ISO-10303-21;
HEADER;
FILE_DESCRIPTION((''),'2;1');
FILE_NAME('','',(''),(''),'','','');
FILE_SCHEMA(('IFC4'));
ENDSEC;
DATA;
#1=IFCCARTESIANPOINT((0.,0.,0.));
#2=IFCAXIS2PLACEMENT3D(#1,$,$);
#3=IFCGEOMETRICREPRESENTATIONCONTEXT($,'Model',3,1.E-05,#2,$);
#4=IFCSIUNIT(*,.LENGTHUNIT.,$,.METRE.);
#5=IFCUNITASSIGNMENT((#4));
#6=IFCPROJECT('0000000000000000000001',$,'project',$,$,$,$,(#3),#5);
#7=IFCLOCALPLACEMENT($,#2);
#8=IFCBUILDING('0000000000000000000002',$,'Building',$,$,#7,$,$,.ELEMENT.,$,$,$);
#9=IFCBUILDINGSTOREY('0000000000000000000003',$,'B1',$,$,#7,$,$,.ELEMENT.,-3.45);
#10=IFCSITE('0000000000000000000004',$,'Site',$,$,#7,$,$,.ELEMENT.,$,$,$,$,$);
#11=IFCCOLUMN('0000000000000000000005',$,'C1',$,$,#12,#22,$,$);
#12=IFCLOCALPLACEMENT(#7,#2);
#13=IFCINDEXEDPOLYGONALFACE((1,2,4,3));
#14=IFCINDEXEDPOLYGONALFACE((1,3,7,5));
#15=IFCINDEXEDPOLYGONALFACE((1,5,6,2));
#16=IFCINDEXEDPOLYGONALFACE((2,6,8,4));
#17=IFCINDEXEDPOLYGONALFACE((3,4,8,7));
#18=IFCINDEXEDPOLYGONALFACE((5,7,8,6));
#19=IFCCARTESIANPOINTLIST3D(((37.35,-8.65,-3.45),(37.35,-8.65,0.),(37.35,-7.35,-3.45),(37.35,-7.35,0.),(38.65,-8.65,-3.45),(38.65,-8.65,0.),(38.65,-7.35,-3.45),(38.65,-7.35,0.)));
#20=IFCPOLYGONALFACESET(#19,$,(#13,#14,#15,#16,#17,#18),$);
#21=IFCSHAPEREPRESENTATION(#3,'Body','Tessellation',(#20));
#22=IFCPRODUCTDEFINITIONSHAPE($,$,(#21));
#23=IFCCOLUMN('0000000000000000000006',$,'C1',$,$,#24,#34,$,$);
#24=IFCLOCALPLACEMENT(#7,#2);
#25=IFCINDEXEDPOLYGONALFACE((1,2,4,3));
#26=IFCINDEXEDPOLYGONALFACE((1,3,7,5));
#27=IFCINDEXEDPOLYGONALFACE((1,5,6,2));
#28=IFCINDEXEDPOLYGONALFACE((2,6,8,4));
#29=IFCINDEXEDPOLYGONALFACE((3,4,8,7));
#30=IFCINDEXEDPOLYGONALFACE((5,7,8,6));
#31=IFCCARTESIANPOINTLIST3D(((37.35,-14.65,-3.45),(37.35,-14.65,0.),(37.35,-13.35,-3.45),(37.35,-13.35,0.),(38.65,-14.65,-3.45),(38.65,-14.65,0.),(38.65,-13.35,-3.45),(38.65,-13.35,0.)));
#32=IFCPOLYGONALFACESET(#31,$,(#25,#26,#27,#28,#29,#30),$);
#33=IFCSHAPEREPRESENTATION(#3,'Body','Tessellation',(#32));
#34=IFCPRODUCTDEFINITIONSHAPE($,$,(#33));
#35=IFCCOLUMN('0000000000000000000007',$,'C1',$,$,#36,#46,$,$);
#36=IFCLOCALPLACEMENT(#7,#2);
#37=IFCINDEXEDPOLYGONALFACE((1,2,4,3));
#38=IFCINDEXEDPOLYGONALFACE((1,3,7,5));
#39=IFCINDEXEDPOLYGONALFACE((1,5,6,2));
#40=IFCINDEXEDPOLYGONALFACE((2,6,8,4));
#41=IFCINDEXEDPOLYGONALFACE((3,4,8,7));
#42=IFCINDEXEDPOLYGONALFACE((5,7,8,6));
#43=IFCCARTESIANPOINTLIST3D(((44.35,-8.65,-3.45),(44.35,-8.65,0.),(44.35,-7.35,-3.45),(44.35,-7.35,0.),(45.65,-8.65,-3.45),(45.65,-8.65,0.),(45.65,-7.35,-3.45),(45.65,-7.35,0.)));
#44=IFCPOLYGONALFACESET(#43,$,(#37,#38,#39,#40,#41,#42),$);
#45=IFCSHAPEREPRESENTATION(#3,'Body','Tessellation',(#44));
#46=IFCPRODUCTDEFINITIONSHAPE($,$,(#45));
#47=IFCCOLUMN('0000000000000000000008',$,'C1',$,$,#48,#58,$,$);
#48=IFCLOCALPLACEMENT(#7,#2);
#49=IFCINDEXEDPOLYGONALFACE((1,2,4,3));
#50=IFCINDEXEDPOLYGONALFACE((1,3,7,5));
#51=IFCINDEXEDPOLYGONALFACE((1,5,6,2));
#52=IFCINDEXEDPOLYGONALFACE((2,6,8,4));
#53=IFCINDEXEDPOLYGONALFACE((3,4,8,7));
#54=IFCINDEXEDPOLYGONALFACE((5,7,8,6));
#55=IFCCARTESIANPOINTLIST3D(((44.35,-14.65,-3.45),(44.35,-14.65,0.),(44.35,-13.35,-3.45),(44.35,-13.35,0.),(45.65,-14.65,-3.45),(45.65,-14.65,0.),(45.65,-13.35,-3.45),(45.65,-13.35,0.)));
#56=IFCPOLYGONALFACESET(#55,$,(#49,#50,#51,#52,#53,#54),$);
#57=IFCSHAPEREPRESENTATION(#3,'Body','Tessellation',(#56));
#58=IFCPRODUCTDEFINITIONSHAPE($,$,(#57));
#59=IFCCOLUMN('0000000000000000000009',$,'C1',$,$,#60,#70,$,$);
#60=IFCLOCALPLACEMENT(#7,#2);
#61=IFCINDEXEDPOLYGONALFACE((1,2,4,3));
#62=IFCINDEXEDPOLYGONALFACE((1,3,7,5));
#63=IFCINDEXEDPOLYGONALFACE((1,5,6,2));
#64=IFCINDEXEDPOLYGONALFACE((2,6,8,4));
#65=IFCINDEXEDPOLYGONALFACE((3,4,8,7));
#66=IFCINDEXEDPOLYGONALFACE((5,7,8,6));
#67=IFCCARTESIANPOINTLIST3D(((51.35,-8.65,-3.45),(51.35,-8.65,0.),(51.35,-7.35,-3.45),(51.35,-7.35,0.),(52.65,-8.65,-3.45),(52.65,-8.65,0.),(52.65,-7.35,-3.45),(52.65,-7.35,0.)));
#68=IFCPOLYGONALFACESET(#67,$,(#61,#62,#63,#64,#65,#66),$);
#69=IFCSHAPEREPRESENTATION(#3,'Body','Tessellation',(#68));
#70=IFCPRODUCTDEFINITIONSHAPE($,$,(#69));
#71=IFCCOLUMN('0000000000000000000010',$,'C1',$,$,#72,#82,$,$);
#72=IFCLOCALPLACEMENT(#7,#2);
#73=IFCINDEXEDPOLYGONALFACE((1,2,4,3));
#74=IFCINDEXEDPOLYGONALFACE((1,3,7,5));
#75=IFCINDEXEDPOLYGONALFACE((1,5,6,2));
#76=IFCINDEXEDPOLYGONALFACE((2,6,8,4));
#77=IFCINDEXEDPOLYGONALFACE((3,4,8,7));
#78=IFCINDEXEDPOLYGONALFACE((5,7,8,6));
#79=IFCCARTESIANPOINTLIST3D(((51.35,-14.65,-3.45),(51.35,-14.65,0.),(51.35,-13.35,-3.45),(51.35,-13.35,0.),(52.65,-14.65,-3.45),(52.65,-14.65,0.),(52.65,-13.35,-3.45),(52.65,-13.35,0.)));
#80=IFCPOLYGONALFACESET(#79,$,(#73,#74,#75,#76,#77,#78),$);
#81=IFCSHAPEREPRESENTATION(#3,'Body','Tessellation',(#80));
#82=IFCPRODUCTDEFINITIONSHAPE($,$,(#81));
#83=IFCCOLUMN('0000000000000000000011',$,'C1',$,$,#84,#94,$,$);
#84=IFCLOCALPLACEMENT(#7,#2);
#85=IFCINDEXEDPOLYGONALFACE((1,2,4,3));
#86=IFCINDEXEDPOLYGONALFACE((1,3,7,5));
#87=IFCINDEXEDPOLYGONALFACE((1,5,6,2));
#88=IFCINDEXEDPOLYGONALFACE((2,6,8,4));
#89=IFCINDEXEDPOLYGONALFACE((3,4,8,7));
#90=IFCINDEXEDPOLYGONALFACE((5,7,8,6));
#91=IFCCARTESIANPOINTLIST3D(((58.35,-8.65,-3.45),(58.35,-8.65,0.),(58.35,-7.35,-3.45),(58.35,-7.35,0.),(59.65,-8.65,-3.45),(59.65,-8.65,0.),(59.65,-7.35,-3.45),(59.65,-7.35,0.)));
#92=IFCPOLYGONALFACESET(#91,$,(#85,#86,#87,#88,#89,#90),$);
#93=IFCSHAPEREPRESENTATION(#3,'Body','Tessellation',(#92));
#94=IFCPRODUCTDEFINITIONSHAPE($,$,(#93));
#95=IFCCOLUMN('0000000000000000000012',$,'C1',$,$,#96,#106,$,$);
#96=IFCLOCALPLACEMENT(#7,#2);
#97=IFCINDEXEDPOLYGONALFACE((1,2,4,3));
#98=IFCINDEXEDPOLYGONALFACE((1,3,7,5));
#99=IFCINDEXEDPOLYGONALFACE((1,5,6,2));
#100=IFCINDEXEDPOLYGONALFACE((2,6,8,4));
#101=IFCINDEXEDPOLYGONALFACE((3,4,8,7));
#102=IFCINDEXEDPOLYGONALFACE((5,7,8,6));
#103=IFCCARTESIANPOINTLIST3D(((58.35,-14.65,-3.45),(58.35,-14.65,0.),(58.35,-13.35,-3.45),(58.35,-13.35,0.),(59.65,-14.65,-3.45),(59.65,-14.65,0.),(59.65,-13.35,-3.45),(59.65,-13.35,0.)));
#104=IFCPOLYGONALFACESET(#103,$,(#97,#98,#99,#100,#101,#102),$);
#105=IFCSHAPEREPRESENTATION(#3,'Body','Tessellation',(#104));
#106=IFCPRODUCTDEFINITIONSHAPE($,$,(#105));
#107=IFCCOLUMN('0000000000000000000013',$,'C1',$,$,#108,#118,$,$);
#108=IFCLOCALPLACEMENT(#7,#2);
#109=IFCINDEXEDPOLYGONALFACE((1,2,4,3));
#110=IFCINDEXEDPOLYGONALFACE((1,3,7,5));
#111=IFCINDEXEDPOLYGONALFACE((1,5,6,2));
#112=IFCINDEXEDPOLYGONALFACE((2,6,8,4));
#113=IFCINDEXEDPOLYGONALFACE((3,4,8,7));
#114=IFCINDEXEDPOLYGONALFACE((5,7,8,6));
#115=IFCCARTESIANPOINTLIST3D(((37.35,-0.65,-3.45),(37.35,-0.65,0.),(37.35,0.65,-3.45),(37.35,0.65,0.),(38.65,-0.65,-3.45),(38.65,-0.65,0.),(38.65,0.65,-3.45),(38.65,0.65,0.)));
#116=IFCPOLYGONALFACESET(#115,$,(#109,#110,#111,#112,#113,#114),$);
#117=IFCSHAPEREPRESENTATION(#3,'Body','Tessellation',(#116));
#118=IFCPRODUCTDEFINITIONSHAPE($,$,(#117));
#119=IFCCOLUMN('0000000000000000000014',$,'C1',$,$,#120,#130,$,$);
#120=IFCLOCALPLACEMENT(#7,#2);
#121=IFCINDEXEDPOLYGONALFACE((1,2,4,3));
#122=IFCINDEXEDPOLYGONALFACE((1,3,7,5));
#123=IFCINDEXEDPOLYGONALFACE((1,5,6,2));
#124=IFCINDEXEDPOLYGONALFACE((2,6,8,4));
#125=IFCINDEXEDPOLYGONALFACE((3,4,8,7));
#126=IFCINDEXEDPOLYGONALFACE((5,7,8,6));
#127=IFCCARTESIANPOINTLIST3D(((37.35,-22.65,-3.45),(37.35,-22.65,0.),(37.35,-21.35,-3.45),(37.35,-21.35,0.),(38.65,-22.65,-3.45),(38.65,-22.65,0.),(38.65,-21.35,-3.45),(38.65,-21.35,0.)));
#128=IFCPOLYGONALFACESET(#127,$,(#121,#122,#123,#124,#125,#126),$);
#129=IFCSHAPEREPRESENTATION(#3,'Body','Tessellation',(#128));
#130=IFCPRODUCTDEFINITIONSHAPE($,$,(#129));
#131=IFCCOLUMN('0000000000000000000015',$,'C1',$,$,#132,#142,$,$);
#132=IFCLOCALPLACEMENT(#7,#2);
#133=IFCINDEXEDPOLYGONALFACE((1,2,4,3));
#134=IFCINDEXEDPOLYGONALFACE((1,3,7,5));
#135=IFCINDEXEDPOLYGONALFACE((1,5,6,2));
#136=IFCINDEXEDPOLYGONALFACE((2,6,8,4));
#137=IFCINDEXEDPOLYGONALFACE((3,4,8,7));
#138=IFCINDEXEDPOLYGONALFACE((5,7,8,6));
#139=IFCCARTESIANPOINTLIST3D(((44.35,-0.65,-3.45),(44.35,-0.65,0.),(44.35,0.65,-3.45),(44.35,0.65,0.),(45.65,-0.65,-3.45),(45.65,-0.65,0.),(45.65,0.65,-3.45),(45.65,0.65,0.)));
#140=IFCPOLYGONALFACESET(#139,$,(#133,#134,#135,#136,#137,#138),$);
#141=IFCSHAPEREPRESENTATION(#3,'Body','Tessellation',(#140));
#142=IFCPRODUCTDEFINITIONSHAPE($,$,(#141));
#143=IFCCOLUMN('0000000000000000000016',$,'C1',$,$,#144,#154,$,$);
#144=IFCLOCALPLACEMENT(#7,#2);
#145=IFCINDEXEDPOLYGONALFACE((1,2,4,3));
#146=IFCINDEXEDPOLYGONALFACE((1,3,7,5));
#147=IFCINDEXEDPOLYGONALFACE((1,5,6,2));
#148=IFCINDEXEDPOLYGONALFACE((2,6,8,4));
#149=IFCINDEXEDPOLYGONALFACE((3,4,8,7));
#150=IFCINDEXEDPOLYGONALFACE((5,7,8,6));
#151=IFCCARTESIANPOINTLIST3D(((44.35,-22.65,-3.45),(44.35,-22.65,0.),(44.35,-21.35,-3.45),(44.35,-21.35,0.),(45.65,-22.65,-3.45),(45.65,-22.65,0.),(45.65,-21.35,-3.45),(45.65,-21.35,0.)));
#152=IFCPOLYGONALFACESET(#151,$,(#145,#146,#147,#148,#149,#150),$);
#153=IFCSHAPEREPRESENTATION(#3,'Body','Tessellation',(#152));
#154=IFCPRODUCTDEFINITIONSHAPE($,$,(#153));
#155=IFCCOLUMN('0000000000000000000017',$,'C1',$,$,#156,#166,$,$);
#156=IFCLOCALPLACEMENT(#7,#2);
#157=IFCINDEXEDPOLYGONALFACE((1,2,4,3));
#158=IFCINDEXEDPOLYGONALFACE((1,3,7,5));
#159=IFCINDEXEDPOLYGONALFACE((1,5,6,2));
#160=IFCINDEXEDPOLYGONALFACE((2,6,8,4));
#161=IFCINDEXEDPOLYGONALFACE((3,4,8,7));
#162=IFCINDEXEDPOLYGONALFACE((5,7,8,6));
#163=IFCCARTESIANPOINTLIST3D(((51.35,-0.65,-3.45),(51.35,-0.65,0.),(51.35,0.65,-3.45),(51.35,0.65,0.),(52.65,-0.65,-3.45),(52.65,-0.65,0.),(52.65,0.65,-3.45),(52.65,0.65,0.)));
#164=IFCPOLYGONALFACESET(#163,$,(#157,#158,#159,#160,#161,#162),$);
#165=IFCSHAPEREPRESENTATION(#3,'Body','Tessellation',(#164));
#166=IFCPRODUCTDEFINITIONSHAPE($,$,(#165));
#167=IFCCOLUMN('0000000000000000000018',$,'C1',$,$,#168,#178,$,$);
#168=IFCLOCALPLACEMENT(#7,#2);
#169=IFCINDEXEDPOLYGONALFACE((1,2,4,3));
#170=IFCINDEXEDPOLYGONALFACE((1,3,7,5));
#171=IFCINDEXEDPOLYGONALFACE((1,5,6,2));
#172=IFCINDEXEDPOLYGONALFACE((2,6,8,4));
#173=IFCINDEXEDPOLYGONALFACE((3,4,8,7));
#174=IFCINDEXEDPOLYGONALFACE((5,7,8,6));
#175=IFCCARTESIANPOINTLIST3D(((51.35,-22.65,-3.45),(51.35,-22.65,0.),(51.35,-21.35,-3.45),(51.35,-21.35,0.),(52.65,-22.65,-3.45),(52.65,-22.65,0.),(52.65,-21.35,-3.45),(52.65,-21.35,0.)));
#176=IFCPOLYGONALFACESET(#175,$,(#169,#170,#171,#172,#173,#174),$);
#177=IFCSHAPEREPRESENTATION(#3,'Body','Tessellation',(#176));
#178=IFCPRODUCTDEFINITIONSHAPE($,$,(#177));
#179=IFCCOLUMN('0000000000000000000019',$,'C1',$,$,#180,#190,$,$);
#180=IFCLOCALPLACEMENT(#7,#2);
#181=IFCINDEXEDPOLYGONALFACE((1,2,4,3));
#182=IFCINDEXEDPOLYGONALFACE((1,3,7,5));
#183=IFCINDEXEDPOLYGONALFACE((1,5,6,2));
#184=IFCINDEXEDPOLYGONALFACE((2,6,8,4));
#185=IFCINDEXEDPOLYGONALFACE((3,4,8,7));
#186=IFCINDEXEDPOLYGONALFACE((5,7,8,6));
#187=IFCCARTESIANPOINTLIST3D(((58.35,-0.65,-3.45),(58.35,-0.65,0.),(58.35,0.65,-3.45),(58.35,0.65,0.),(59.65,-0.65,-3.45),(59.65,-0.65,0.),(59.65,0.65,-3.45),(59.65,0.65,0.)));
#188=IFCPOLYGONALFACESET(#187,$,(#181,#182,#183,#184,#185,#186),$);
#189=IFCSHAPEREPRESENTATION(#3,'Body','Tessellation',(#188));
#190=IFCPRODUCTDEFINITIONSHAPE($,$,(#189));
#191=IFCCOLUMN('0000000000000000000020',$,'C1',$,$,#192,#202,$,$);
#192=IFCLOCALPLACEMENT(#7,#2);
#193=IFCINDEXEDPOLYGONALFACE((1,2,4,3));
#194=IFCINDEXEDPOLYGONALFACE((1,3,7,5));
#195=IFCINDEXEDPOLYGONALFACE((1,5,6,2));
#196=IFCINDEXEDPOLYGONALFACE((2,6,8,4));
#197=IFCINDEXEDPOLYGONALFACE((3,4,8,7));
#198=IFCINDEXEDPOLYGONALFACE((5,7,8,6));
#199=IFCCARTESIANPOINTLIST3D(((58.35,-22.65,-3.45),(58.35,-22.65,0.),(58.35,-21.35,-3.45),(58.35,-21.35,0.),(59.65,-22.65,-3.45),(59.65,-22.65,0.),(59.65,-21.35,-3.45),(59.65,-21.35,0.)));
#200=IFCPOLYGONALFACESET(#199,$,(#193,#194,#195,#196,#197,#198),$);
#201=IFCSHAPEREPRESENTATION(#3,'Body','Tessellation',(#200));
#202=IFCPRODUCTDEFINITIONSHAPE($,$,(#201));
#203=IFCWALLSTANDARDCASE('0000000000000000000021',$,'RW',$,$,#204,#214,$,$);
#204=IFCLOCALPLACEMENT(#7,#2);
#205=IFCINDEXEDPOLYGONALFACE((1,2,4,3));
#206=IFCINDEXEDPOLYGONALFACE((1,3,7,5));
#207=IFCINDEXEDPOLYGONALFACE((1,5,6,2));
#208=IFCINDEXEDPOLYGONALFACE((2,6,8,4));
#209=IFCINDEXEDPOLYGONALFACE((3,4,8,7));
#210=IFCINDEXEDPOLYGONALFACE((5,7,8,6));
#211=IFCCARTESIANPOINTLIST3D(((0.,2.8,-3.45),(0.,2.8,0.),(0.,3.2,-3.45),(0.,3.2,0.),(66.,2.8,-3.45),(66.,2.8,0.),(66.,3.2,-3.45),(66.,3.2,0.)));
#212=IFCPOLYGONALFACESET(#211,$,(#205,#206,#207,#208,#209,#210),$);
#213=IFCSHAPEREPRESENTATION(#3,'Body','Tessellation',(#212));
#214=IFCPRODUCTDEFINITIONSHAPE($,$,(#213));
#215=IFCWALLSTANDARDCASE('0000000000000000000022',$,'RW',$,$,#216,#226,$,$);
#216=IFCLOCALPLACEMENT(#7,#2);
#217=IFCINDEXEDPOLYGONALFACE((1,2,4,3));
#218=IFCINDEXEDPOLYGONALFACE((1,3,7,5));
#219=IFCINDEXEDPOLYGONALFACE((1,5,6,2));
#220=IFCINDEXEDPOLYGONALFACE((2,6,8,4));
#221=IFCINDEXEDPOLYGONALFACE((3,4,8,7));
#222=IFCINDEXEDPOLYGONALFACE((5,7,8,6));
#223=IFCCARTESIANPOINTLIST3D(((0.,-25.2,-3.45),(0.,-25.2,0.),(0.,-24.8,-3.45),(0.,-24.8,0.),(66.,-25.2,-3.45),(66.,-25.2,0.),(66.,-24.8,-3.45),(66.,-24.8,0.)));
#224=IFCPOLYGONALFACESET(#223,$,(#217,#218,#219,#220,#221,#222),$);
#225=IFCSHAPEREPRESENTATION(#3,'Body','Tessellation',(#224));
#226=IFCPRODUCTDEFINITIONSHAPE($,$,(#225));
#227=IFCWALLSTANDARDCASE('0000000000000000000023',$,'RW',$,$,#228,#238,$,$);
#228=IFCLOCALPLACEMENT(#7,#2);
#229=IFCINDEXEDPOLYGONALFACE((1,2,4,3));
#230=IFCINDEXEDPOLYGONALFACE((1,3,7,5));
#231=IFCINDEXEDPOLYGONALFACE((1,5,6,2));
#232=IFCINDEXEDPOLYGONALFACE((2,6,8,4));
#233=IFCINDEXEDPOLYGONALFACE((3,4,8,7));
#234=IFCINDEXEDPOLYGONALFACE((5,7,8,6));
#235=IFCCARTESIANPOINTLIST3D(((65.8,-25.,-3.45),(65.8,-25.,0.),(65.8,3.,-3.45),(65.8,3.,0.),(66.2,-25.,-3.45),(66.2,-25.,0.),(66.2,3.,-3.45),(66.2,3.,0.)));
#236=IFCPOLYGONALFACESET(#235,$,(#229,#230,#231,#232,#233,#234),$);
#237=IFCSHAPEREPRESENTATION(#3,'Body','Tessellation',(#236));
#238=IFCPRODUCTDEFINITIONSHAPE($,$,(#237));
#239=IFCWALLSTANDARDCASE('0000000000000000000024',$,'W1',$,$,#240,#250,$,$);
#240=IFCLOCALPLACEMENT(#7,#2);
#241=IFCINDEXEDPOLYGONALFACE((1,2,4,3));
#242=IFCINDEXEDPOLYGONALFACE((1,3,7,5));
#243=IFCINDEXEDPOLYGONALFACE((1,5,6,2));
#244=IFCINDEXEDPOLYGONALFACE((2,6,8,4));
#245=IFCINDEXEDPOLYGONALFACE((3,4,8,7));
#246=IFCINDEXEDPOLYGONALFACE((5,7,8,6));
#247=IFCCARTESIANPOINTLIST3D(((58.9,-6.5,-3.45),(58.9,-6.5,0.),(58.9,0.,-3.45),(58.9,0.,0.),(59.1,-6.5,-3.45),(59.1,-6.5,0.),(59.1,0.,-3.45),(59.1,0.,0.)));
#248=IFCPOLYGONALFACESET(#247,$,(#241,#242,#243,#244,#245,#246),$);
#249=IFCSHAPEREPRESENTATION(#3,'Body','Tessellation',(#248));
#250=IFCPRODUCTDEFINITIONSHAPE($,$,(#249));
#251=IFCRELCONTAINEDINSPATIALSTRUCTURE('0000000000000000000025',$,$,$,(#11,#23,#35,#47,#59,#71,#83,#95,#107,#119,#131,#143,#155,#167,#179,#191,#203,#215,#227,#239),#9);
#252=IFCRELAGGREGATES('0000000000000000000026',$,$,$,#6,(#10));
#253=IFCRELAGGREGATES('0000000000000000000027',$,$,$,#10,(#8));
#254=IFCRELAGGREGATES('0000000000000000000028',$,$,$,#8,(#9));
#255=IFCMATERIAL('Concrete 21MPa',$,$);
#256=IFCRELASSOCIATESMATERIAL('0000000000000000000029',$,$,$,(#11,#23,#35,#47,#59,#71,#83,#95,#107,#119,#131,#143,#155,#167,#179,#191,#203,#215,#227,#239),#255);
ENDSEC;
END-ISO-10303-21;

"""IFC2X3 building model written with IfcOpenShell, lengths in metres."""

from ifc_helpers import new_model, si_unit, frame, origin, origin_2d, place, context, project, spatial, rectangle, extrude, material, element, save


model = new_model("IFC2X3")

# Units and contexts
model_context = context("Model", 3, precision=1e-05, world=origin())
ifc_project = project(units=[si_unit("LENGTHUNIT", "METRE")], contexts=[model_context])

# Site, building, storey
placement = place(None, origin())
site = spatial("IfcSite", under=ifc_project, at=placement, Name="Site", CompositionType="ELEMENT")
building = spatial("IfcBuilding", under=site, at=placement, Name="Building", CompositionType="ELEMENT")
storey = spatial("IfcBuildingStorey", under=building, at=placement, Name="B1", CompositionType="ELEMENT", Elevation=-3.45)

# Columns
ifc_material_1 = material(Name="Concrete 21MPa")
for number, where, name in (
    (1, (38.0, -8.0, -3.45), "C1"),
    (2, (38.0, -14.0, -3.45), "C1"),
    (3, (45.0, -8.0, -3.45), "C1"),
    (4, (45.0, -14.0, -3.45), "C1"),
    (5, (52.0, -8.0, -3.45), "C1"),
    (6, (52.0, -14.0, -3.45), "C1"),
    (7, (59.0, -8.0, -3.45), "C1"),
    (8, (59.0, -14.0, -3.45), "C1"),
    (9, (38.0, 0.0, -3.45), "C1"),
    (10, (38.0, -22.0, -3.45), "C1"),
    (11, (45.0, 0.0, -3.45), "C1"),
    (12, (45.0, -22.0, -3.45), "C1"),
    (13, (52.0, 0.0, -3.45), "C1"),
    (14, (52.0, -22.0, -3.45), "C1"),
    (15, (59.0, 0.0, -3.45), "C1"),
    (16, (59.0, -22.0, -3.45), "C1"),
):
    element("IfcColumn", number, at=place(None, frame(where)), inside=storey, material=ifc_material_1, Name=name, context=model_context, shape_type="SweptSolid", body=[
        extrude(rectangle(XDim=1.3, YDim=1.3, at=origin_2d()), origin(), (0.0, 0.0, 1.0), 3.45),
    ])

# Walls
for number, where, name in (
    (17, (33.0, 3.0, -3.45), "RW"),
    (18, (33.0, -25.0, -3.45), "RW"),
):
    element("IfcWallStandardCase", number, at=place(None, frame(where)), inside=storey, material=ifc_material_1, Name=name, context=model_context, shape_type="SweptSolid", body=[
        extrude(rectangle(XDim=66.0, YDim=0.4, at=origin_2d()), origin(), (0.0, 0.0, 1.0), 3.45),
    ])
wall_1_placement = place(None, frame((66.0, -11.0, -3.45)))
element("IfcWallStandardCase", 19, at=wall_1_placement, inside=storey, material=ifc_material_1, Name="RW", context=model_context, shape_type="SweptSolid", body=[
    extrude(rectangle(XDim=0.4, YDim=28.0, at=origin_2d()), origin(), (0.0, 0.0, 1.0), 3.45),
])
wall_2_placement = place(None, frame((59.0, -3.25, -3.45)))
element("IfcWallStandardCase", 20, at=wall_2_placement, inside=storey, material=ifc_material_1, Name="W1", context=model_context, shape_type="SweptSolid", body=[
    extrude(rectangle(XDim=0.2, YDim=6.5, at=origin_2d()), origin(), (0.0, 0.0, 1.0), 3.45),
])

save(model, "model.ifc")
